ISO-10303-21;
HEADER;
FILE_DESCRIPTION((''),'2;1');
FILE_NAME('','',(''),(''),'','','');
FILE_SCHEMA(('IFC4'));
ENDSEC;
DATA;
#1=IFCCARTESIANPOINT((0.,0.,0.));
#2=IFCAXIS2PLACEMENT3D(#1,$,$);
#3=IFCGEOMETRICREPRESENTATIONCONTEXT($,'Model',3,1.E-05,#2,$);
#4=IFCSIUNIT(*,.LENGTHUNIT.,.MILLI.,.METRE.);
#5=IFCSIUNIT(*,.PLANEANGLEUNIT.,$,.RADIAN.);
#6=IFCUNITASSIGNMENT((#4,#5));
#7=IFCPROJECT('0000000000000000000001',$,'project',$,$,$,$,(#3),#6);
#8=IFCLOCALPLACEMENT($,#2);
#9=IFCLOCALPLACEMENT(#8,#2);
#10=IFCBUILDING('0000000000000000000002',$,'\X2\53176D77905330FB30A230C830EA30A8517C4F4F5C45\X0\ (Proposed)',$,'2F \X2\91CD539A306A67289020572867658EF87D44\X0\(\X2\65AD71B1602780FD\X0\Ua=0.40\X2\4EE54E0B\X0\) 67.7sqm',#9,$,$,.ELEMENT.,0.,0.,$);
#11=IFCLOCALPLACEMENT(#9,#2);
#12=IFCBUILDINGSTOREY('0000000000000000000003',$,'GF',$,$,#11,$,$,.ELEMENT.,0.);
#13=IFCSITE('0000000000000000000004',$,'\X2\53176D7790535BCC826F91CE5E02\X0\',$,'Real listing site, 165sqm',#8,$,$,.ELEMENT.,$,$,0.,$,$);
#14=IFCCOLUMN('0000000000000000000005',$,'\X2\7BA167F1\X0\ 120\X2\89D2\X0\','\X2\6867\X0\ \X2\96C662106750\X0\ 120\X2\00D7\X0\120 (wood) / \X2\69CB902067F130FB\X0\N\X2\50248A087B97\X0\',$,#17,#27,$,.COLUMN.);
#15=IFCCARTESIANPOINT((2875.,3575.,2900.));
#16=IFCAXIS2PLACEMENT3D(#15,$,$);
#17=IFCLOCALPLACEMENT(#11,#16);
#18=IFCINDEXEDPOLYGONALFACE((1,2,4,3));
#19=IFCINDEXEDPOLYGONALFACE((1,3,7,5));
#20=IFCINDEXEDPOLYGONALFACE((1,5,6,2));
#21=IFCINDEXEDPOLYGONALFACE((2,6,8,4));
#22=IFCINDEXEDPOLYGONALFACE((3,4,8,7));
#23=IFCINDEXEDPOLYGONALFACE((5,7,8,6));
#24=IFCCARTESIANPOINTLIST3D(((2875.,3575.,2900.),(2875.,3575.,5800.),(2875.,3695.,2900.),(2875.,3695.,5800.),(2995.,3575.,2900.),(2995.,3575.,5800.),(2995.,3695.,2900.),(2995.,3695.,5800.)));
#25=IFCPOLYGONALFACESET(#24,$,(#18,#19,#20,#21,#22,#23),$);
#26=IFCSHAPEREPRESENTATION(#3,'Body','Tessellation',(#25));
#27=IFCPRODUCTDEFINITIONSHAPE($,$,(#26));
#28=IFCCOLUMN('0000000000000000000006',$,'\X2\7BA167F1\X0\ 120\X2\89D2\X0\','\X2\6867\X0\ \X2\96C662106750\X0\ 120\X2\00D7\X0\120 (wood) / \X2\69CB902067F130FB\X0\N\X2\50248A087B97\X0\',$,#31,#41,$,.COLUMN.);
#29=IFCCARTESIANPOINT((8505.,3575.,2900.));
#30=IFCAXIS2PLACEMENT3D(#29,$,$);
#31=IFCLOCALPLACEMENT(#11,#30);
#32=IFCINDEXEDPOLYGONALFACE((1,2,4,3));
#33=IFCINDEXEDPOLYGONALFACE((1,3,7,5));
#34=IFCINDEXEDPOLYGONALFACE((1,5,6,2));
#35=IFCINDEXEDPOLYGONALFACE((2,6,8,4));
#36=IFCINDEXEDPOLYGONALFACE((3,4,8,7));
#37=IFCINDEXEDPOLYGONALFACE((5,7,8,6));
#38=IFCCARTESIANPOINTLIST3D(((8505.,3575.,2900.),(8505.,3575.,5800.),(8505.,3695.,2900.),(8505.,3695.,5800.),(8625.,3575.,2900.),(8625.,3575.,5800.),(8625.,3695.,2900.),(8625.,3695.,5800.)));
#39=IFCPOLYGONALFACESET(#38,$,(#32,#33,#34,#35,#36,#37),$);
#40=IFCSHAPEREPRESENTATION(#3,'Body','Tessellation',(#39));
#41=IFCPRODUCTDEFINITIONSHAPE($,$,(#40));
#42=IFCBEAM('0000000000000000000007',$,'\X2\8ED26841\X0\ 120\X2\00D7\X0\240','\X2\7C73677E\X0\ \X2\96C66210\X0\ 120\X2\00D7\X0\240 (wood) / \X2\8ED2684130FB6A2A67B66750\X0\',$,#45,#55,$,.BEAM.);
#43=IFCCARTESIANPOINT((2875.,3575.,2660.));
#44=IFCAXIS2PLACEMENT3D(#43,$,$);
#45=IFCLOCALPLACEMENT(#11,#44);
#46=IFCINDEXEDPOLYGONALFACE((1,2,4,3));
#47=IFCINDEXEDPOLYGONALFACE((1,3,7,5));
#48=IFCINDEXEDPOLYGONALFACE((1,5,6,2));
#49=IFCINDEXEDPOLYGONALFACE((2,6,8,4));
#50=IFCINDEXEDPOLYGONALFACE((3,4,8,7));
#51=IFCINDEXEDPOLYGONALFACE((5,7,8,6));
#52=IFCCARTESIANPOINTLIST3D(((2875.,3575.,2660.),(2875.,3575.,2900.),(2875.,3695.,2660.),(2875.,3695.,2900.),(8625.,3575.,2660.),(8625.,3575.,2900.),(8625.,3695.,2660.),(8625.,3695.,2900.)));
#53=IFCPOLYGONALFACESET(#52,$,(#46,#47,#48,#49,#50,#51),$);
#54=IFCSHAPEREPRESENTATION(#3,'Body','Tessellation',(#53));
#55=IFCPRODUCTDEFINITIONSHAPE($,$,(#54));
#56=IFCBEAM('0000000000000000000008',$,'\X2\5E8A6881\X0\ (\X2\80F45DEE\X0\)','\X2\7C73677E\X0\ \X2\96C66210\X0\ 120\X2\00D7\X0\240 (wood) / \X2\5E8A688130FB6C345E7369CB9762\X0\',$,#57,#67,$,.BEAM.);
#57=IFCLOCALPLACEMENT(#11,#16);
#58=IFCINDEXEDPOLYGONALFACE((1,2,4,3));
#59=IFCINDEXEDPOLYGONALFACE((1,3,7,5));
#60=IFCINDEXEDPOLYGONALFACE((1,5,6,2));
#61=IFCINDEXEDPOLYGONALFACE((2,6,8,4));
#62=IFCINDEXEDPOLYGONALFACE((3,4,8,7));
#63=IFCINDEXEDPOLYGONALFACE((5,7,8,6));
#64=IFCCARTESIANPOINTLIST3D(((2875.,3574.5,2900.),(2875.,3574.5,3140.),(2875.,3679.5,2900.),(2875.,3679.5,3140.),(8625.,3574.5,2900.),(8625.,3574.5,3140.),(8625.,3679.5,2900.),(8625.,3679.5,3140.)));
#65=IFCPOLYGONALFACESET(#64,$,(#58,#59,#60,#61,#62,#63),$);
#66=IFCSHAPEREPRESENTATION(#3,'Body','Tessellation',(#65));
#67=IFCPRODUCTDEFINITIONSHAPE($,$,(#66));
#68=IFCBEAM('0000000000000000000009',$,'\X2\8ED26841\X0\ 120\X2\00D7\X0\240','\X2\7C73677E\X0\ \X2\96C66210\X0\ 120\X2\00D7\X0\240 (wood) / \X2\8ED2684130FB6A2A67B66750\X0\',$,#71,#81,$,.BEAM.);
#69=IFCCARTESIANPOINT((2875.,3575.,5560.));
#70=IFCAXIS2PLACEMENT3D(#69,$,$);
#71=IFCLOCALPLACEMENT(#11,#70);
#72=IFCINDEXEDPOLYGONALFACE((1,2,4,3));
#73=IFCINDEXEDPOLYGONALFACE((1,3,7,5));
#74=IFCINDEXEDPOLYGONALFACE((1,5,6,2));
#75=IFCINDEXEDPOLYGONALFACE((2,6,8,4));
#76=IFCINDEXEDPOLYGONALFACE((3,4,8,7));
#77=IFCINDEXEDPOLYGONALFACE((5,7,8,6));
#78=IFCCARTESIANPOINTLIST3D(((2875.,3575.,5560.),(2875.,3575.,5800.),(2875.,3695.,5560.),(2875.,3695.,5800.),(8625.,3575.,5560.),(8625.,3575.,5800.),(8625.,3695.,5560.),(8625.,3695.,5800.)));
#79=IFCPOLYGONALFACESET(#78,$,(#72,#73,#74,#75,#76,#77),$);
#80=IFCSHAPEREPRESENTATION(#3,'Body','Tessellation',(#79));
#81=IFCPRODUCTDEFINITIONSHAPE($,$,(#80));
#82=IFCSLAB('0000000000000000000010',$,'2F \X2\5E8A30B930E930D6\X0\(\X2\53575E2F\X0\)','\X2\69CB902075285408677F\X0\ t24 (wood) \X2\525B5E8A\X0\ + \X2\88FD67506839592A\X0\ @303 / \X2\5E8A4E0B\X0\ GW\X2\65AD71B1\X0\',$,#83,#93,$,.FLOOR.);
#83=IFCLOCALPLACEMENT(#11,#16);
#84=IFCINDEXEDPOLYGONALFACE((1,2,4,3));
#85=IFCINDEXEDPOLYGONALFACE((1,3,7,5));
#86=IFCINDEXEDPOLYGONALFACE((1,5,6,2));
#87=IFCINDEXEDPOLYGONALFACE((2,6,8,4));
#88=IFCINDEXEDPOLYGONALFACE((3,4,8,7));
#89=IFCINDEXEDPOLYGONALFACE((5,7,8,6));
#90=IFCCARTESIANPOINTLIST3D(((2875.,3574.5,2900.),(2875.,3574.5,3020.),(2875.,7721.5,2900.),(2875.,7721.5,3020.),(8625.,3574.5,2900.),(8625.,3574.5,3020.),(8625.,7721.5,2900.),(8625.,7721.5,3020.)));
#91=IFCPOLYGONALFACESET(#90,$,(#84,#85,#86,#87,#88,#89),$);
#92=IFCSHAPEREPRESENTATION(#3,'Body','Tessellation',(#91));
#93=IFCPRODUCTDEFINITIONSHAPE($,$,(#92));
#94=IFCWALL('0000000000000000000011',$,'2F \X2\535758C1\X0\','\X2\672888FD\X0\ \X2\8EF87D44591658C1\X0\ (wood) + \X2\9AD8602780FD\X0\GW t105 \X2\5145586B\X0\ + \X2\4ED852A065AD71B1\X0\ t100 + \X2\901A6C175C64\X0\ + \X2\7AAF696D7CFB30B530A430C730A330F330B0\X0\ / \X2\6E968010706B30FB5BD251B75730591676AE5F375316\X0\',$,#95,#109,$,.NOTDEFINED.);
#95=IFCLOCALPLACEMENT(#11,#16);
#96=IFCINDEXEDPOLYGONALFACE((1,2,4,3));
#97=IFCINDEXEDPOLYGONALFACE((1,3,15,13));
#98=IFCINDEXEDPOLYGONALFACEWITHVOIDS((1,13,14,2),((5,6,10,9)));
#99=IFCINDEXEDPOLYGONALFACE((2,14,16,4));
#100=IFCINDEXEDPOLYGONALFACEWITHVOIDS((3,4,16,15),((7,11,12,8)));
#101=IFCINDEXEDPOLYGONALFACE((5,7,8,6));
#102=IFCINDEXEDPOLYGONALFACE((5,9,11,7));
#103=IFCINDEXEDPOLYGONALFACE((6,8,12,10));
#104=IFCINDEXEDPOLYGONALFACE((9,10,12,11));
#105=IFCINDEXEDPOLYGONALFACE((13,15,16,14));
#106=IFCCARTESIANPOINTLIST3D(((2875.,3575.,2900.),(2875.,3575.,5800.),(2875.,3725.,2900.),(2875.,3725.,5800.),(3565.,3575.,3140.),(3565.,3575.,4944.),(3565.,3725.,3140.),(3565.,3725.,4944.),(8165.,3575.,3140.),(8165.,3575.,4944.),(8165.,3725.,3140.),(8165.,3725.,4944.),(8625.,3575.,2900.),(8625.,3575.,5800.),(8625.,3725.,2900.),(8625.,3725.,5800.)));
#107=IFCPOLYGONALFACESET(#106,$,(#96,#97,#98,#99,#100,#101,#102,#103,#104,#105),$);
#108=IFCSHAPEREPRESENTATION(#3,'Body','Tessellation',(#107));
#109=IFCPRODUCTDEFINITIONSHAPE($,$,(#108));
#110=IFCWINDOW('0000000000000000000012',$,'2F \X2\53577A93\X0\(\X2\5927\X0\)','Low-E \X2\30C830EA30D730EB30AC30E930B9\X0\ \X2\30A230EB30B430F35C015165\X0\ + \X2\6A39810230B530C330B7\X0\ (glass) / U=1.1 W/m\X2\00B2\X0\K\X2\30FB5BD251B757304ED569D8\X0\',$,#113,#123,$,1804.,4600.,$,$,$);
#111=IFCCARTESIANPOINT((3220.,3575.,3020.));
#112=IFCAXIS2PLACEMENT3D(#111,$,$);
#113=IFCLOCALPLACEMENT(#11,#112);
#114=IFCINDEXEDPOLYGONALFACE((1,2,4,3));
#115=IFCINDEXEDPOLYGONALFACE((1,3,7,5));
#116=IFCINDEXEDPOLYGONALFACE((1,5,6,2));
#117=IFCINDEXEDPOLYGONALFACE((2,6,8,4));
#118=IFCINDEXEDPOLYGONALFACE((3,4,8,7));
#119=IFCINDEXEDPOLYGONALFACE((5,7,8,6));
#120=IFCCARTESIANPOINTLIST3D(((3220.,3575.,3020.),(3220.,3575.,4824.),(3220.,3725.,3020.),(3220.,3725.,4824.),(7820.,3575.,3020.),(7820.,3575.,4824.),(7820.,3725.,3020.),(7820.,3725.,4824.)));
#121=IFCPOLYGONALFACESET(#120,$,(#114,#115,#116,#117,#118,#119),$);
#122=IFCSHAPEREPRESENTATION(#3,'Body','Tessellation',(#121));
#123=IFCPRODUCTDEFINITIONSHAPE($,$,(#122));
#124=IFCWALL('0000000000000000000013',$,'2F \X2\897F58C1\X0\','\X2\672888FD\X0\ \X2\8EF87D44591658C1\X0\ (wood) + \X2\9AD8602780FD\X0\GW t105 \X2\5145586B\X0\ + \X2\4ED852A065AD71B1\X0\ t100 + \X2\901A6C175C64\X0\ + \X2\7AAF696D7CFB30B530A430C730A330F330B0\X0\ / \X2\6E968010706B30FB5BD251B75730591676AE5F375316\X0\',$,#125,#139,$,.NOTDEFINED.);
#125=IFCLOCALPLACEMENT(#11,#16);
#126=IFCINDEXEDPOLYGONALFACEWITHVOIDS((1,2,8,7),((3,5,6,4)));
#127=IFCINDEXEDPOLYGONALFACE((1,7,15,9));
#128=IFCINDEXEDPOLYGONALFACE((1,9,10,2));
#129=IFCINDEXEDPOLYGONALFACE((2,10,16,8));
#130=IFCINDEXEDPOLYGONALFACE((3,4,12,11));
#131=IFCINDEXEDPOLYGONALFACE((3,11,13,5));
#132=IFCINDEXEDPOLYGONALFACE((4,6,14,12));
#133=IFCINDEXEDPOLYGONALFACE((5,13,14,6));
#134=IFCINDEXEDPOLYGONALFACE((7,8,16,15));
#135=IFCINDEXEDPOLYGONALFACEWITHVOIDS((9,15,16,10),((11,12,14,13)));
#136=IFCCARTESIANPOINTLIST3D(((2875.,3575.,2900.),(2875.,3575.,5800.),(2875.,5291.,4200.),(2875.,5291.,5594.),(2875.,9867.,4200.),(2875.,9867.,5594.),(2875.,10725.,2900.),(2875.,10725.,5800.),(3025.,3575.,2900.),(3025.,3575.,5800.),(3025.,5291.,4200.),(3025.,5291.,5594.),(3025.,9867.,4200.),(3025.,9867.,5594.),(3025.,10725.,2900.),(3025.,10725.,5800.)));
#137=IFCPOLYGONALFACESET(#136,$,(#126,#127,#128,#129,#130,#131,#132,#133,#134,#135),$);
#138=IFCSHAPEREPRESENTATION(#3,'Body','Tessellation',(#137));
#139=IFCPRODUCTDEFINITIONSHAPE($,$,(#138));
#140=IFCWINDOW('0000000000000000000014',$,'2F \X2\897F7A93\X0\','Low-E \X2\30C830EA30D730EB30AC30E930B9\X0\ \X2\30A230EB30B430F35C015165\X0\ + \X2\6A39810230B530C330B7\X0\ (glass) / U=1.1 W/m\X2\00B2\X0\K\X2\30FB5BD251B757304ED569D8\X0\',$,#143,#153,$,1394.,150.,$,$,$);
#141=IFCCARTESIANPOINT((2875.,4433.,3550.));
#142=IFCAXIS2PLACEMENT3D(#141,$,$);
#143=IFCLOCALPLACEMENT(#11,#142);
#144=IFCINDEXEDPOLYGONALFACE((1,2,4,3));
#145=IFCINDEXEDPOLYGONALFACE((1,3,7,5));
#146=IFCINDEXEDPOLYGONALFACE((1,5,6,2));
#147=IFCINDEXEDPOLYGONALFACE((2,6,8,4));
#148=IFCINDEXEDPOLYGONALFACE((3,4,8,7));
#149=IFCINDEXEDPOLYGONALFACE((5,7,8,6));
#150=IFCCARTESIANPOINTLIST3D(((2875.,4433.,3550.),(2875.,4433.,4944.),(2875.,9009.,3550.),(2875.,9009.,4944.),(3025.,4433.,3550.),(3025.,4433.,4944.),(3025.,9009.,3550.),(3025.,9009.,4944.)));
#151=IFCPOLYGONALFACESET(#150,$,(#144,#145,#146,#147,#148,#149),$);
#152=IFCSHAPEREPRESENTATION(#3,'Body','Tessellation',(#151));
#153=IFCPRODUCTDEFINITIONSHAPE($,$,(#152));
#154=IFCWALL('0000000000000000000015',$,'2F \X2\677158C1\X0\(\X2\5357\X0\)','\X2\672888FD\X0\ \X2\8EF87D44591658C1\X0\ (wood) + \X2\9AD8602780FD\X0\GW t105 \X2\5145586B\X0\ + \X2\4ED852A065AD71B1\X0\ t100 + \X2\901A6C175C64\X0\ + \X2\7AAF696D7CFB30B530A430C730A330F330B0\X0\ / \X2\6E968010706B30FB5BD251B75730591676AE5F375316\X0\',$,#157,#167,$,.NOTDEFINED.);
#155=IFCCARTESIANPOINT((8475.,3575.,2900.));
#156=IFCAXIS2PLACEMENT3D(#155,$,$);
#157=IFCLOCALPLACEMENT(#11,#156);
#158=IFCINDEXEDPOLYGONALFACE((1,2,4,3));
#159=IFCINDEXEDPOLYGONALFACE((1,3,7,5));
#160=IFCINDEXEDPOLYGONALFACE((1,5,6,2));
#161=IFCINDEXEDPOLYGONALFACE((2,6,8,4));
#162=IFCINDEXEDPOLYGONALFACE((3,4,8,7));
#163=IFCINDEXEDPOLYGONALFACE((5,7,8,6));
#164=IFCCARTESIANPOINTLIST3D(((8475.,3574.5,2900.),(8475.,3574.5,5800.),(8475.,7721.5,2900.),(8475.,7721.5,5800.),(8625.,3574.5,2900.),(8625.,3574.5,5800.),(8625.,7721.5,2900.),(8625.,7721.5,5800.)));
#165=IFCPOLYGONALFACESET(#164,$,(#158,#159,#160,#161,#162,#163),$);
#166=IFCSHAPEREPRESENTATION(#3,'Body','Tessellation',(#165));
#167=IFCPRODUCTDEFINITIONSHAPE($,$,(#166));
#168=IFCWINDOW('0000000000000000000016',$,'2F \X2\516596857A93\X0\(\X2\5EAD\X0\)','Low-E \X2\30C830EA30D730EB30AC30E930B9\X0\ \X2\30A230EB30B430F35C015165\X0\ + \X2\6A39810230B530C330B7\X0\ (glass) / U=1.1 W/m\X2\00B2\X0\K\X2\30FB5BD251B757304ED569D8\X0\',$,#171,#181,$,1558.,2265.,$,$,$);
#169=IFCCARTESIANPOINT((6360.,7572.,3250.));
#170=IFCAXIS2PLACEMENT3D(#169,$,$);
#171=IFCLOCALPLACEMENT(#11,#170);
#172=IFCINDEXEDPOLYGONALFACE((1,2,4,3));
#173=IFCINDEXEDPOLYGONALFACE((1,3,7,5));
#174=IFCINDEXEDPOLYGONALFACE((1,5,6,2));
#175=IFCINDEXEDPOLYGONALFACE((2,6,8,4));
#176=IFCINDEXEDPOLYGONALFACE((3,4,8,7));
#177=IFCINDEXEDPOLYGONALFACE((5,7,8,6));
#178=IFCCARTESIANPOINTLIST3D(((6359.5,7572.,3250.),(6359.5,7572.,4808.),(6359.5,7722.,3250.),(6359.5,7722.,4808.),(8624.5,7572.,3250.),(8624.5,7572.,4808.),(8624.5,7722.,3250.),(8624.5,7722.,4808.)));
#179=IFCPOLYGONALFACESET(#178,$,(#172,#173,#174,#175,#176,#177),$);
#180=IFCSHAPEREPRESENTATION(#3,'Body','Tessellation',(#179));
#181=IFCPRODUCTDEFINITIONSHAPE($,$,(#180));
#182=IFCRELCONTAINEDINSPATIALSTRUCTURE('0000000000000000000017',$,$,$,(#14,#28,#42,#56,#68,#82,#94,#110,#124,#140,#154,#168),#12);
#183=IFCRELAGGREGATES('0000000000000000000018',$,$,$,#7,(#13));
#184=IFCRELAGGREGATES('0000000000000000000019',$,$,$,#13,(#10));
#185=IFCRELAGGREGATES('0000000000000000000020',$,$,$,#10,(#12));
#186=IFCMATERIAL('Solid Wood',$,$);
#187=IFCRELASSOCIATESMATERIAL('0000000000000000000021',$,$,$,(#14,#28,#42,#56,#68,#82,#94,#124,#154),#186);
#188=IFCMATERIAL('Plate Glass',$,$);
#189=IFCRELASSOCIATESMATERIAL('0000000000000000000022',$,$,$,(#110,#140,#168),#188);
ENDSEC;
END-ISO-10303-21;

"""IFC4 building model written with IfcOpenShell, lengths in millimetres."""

from ifc_helpers import new_model, si_unit, frame, frame_2d, origin, place, context, project, spatial, rectangle, extrude, material, element, fill, save


model = new_model("IFC4")

# Units and contexts
model_context = context("Model", 3, precision=1e-05, world=origin())
ifc_project = project(units=[si_unit("LENGTHUNIT", "METRE", prefix="MILLI"), si_unit("PLANEANGLEUNIT", "RADIAN")], contexts=[model_context])

# Site, building, storey
site_placement = place(None, origin())
site = spatial("IfcSite", under=ifc_project, at=site_placement, Name="北海道富良野市", ObjectType="Real listing site, 165sqm", CompositionType="ELEMENT", RefElevation=0.0)
building_placement = place(site_placement, origin())
building = spatial("IfcBuilding", under=site, at=building_placement, Name="北海道・アトリエ兼住居 (Proposed)", ObjectType="2F 重厚な木造在来軸組(断熱性能Ua=0.40以下) 67.7sqm", CompositionType="ELEMENT", ElevationOfRefHeight=0.0, ElevationOfTerrain=0.0)
storey_placement = place(building_placement, origin())
storey = spatial("IfcBuildingStorey", under=building, at=storey_placement, Name="GF", CompositionType="ELEMENT", Elevation=0.0)

# Columns
ifc_material_1 = material(Name="Solid Wood")
column_1_placement = place(storey_placement, frame((2875.0, 3575.0, 2900.0)))
element("IfcColumn", 1, at=column_1_placement, inside=storey, material=ifc_material_1, Name="管柱 120角", Description="桧 集成材 120×120 (wood) / 構造柱・N値計算", PredefinedType="COLUMN", context=model_context, shape_type="SweptSolid", body=[
    extrude(rectangle(XDim=120.0, YDim=120.0, at=frame_2d((60.0, 60.0))), frame((2875.0, 3575.0, 2900.0)), (0.0, 0.0, 1.0), 2900.0),
])
column_2_placement = place(storey_placement, frame((8505.0, 3575.0, 2900.0)))
element("IfcColumn", 2, at=column_2_placement, inside=storey, material=ifc_material_1, Name="管柱 120角", Description="桧 集成材 120×120 (wood) / 構造柱・N値計算", PredefinedType="COLUMN", context=model_context, shape_type="SweptSolid", body=[
    extrude(rectangle(XDim=120.0, YDim=120.0, at=frame_2d((60.0, 60.0))), frame((8505.0, 3575.0, 2900.0)), (0.0, 0.0, 1.0), 2900.0),
])

# Beams
beam_1_placement = place(storey_placement, frame((2875.0, 3575.0, 2660.0)))
element("IfcBeam", 3, at=beam_1_placement, inside=storey, material=ifc_material_1, Name="軒桁 120×240", Description="米松 集成 120×240 (wood) / 軒桁・横架材", PredefinedType="BEAM", context=model_context, shape_type="SweptSolid", body=[
    extrude(rectangle(XDim=5750.0, YDim=120.0, at=frame_2d((2875.0, 60.0))), frame((2875.0, 3575.0, 2660.0)), (0.0, 0.0, 1.0), 240.0),
])
beam_2_placement = place(storey_placement, frame((2875.0, 3575.0, 2900.0)))
element("IfcBeam", 4, at=beam_2_placement, inside=storey, material=ifc_material_1, Name="床梁 (胴差)", Description="米松 集成 120×240 (wood) / 床梁・水平構面", PredefinedType="BEAM", context=model_context, shape_type="SweptSolid", body=[
    extrude(rectangle(XDim=5750.0, YDim=105.0, at=frame_2d((2875.0, 52.0))), frame((2875.0, 3575.0, 2900.0)), (0.0, 0.0, 1.0), 240.0),
])
beam_3_placement = place(storey_placement, frame((2875.0, 3575.0, 5560.0)))
element("IfcBeam", 5, at=beam_3_placement, inside=storey, material=ifc_material_1, Name="軒桁 120×240", Description="米松 集成 120×240 (wood) / 軒桁・横架材", PredefinedType="BEAM", context=model_context, shape_type="SweptSolid", body=[
    extrude(rectangle(XDim=5750.0, YDim=120.0, at=frame_2d((2875.0, 60.0))), frame((2875.0, 3575.0, 5560.0)), (0.0, 0.0, 1.0), 240.0),
])

# Slab
slab_placement = place(storey_placement, frame((2875.0, 3575.0, 2900.0)))
element("IfcSlab", 6, at=slab_placement, inside=storey, material=ifc_material_1, Name="2F 床スラブ(南帯)", Description="構造用合板 t24 (wood) 剛床 + 製材根太 @303 / 床下 GW断熱", PredefinedType="FLOOR", context=model_context, shape_type="SweptSolid", body=[
    extrude(rectangle(XDim=5750.0, YDim=4147.0, at=frame_2d((2875.0, 2073.0))), frame((2875.0, 3575.0, 2900.0)), (0.0, 0.0, 1.0), 120.0),
])

# Walls, openings, windows
wall_1_placement = place(storey_placement, frame((2875.0, 3575.0, 2900.0)))
wall_1 = element("IfcWall", 7, at=wall_1_placement, inside=storey, material=ifc_material_1, Name="2F 南壁", Description="木製 軸組外壁 (wood) + 高性能GW t105 充填 + 付加断熱 t100 + 通気層 + 窯業系サイディング / 準耐火・寒冷地外皮強化", PredefinedType="NOTDEFINED", context=model_context, shape_type="SweptSolid", body=[
    extrude(rectangle(XDim=5750.0, YDim=150.0, at=frame_2d((2875.0, 75.0))), frame((2875.0, 3575.0, 2900.0)), (0.0, 0.0, 1.0), 2900.0),
])
opening_1_placement = place(storey_placement, frame((3220.0, 3575.0, 3020.0)))
opening_1 = element("IfcOpeningElement", 8, at=opening_1_placement, cuts=wall_1, PredefinedType="NOTDEFINED", context=model_context, shape_type="SweptSolid", body=[
    extrude(rectangle(XDim=4600.0, YDim=150.0, at=frame_2d((2300.0, 75.0))), frame((3220.0, 3575.0, 3020.0)), (0.0, 0.0, 1.0), 1804.0),
])
ifc_material_2 = material(Name="Plate Glass")
window_1_placement = place(storey_placement, frame((3220.0, 3575.0, 3020.0)))
window_1 = element("IfcWindow", 9, at=window_1_placement, inside=storey, material=ifc_material_2, Name="2F 南窓(大)", Description="Low-E トリプルガラス アルゴン封入 + 樹脂サッシ (glass) / U=1.1 W/m²K・寒冷地仕様", OverallHeight=1804.0, OverallWidth=4600.0, context=model_context, shape_type="SweptSolid", body=[
    extrude(rectangle(XDim=4600.0, YDim=150.0, at=frame_2d((2300.0, 75.0))), frame((3220.0, 3575.0, 3020.0)), (0.0, 0.0, 1.0), 1804.0),
])
fill(opening_1, window_1)
wall_2_placement = place(storey_placement, frame((2875.0, 3575.0, 2900.0)))
wall_2 = element("IfcWall", 10, at=wall_2_placement, inside=storey, material=ifc_material_1, Name="2F 西壁", Description="木製 軸組外壁 (wood) + 高性能GW t105 充填 + 付加断熱 t100 + 通気層 + 窯業系サイディング / 準耐火・寒冷地外皮強化", PredefinedType="NOTDEFINED", context=model_context, shape_type="SweptSolid", body=[
    extrude(rectangle(XDim=150.0, YDim=7150.0, at=frame_2d((75.0, 3575.0))), frame((2875.0, 3575.0, 2900.0)), (0.0, 0.0, 1.0), 2900.0),
])
opening_2_placement = place(storey_placement, frame((2875.0, 4433.0, 3550.0)))
opening_2 = element("IfcOpeningElement", 11, at=opening_2_placement, cuts=wall_2, PredefinedType="NOTDEFINED", context=model_context, shape_type="SweptSolid", body=[
    extrude(rectangle(XDim=150.0, YDim=4576.0, at=frame_2d((75.0, 2288.0))), frame((2875.0, 4433.0, 3550.0)), (0.0, 0.0, 1.0), 1394.0),
])
window_2_placement = place(storey_placement, frame((2875.0, 4433.0, 3550.0)))
window_2 = element("IfcWindow", 12, at=window_2_placement, inside=storey, material=ifc_material_2, Name="2F 西窓", Description="Low-E トリプルガラス アルゴン封入 + 樹脂サッシ (glass) / U=1.1 W/m²K・寒冷地仕様", OverallHeight=1394.0, OverallWidth=150.0, context=model_context, shape_type="SweptSolid", body=[
    extrude(rectangle(XDim=150.0, YDim=4576.0, at=frame_2d((75.0, 2288.0))), frame((2875.0, 4433.0, 3550.0)), (0.0, 0.0, 1.0), 1394.0),
])
fill(opening_2, window_2)
wall_3_placement = place(storey_placement, frame((8475.0, 3575.0, 2900.0)))
wall_3 = element("IfcWall", 13, at=wall_3_placement, inside=storey, material=ifc_material_1, Name="2F 東壁(南)", Description="木製 軸組外壁 (wood) + 高性能GW t105 充填 + 付加断熱 t100 + 通気層 + 窯業系サイディング / 準耐火・寒冷地外皮強化", PredefinedType="NOTDEFINED", context=model_context, shape_type="SweptSolid", body=[
    extrude(rectangle(XDim=150.0, YDim=4147.0, at=frame_2d((75.0, 2073.0))), frame((8475.0, 3575.0, 2900.0)), (0.0, 0.0, 1.0), 2900.0),
])
opening_3_placement = place(storey_placement, frame((6360.0, 7572.0, 3250.0)))
opening_3 = element("IfcOpeningElement", 14, at=opening_3_placement, cuts=wall_3, PredefinedType="NOTDEFINED", context=model_context, shape_type="SweptSolid", body=[
    extrude(rectangle(XDim=2265.0, YDim=150.0, at=frame_2d((1132.0, 75.0))), frame((6360.0, 7572.0, 3250.0)), (0.0, 0.0, 1.0), 1558.0),
])
window_3_placement = place(storey_placement, frame((6360.0, 7572.0, 3250.0)))
window_3 = element("IfcWindow", 15, at=window_3_placement, inside=storey, material=ifc_material_2, Name="2F 入隅窓(庭)", Description="Low-E トリプルガラス アルゴン封入 + 樹脂サッシ (glass) / U=1.1 W/m²K・寒冷地仕様", OverallHeight=1558.0, OverallWidth=2265.0, context=model_context, shape_type="SweptSolid", body=[
    extrude(rectangle(XDim=2265.0, YDim=150.0, at=frame_2d((1132.0, 75.0))), frame((6360.0, 7572.0, 3250.0)), (0.0, 0.0, 1.0), 1558.0),
])
fill(opening_3, window_3)

save(model, "model.ifc")
